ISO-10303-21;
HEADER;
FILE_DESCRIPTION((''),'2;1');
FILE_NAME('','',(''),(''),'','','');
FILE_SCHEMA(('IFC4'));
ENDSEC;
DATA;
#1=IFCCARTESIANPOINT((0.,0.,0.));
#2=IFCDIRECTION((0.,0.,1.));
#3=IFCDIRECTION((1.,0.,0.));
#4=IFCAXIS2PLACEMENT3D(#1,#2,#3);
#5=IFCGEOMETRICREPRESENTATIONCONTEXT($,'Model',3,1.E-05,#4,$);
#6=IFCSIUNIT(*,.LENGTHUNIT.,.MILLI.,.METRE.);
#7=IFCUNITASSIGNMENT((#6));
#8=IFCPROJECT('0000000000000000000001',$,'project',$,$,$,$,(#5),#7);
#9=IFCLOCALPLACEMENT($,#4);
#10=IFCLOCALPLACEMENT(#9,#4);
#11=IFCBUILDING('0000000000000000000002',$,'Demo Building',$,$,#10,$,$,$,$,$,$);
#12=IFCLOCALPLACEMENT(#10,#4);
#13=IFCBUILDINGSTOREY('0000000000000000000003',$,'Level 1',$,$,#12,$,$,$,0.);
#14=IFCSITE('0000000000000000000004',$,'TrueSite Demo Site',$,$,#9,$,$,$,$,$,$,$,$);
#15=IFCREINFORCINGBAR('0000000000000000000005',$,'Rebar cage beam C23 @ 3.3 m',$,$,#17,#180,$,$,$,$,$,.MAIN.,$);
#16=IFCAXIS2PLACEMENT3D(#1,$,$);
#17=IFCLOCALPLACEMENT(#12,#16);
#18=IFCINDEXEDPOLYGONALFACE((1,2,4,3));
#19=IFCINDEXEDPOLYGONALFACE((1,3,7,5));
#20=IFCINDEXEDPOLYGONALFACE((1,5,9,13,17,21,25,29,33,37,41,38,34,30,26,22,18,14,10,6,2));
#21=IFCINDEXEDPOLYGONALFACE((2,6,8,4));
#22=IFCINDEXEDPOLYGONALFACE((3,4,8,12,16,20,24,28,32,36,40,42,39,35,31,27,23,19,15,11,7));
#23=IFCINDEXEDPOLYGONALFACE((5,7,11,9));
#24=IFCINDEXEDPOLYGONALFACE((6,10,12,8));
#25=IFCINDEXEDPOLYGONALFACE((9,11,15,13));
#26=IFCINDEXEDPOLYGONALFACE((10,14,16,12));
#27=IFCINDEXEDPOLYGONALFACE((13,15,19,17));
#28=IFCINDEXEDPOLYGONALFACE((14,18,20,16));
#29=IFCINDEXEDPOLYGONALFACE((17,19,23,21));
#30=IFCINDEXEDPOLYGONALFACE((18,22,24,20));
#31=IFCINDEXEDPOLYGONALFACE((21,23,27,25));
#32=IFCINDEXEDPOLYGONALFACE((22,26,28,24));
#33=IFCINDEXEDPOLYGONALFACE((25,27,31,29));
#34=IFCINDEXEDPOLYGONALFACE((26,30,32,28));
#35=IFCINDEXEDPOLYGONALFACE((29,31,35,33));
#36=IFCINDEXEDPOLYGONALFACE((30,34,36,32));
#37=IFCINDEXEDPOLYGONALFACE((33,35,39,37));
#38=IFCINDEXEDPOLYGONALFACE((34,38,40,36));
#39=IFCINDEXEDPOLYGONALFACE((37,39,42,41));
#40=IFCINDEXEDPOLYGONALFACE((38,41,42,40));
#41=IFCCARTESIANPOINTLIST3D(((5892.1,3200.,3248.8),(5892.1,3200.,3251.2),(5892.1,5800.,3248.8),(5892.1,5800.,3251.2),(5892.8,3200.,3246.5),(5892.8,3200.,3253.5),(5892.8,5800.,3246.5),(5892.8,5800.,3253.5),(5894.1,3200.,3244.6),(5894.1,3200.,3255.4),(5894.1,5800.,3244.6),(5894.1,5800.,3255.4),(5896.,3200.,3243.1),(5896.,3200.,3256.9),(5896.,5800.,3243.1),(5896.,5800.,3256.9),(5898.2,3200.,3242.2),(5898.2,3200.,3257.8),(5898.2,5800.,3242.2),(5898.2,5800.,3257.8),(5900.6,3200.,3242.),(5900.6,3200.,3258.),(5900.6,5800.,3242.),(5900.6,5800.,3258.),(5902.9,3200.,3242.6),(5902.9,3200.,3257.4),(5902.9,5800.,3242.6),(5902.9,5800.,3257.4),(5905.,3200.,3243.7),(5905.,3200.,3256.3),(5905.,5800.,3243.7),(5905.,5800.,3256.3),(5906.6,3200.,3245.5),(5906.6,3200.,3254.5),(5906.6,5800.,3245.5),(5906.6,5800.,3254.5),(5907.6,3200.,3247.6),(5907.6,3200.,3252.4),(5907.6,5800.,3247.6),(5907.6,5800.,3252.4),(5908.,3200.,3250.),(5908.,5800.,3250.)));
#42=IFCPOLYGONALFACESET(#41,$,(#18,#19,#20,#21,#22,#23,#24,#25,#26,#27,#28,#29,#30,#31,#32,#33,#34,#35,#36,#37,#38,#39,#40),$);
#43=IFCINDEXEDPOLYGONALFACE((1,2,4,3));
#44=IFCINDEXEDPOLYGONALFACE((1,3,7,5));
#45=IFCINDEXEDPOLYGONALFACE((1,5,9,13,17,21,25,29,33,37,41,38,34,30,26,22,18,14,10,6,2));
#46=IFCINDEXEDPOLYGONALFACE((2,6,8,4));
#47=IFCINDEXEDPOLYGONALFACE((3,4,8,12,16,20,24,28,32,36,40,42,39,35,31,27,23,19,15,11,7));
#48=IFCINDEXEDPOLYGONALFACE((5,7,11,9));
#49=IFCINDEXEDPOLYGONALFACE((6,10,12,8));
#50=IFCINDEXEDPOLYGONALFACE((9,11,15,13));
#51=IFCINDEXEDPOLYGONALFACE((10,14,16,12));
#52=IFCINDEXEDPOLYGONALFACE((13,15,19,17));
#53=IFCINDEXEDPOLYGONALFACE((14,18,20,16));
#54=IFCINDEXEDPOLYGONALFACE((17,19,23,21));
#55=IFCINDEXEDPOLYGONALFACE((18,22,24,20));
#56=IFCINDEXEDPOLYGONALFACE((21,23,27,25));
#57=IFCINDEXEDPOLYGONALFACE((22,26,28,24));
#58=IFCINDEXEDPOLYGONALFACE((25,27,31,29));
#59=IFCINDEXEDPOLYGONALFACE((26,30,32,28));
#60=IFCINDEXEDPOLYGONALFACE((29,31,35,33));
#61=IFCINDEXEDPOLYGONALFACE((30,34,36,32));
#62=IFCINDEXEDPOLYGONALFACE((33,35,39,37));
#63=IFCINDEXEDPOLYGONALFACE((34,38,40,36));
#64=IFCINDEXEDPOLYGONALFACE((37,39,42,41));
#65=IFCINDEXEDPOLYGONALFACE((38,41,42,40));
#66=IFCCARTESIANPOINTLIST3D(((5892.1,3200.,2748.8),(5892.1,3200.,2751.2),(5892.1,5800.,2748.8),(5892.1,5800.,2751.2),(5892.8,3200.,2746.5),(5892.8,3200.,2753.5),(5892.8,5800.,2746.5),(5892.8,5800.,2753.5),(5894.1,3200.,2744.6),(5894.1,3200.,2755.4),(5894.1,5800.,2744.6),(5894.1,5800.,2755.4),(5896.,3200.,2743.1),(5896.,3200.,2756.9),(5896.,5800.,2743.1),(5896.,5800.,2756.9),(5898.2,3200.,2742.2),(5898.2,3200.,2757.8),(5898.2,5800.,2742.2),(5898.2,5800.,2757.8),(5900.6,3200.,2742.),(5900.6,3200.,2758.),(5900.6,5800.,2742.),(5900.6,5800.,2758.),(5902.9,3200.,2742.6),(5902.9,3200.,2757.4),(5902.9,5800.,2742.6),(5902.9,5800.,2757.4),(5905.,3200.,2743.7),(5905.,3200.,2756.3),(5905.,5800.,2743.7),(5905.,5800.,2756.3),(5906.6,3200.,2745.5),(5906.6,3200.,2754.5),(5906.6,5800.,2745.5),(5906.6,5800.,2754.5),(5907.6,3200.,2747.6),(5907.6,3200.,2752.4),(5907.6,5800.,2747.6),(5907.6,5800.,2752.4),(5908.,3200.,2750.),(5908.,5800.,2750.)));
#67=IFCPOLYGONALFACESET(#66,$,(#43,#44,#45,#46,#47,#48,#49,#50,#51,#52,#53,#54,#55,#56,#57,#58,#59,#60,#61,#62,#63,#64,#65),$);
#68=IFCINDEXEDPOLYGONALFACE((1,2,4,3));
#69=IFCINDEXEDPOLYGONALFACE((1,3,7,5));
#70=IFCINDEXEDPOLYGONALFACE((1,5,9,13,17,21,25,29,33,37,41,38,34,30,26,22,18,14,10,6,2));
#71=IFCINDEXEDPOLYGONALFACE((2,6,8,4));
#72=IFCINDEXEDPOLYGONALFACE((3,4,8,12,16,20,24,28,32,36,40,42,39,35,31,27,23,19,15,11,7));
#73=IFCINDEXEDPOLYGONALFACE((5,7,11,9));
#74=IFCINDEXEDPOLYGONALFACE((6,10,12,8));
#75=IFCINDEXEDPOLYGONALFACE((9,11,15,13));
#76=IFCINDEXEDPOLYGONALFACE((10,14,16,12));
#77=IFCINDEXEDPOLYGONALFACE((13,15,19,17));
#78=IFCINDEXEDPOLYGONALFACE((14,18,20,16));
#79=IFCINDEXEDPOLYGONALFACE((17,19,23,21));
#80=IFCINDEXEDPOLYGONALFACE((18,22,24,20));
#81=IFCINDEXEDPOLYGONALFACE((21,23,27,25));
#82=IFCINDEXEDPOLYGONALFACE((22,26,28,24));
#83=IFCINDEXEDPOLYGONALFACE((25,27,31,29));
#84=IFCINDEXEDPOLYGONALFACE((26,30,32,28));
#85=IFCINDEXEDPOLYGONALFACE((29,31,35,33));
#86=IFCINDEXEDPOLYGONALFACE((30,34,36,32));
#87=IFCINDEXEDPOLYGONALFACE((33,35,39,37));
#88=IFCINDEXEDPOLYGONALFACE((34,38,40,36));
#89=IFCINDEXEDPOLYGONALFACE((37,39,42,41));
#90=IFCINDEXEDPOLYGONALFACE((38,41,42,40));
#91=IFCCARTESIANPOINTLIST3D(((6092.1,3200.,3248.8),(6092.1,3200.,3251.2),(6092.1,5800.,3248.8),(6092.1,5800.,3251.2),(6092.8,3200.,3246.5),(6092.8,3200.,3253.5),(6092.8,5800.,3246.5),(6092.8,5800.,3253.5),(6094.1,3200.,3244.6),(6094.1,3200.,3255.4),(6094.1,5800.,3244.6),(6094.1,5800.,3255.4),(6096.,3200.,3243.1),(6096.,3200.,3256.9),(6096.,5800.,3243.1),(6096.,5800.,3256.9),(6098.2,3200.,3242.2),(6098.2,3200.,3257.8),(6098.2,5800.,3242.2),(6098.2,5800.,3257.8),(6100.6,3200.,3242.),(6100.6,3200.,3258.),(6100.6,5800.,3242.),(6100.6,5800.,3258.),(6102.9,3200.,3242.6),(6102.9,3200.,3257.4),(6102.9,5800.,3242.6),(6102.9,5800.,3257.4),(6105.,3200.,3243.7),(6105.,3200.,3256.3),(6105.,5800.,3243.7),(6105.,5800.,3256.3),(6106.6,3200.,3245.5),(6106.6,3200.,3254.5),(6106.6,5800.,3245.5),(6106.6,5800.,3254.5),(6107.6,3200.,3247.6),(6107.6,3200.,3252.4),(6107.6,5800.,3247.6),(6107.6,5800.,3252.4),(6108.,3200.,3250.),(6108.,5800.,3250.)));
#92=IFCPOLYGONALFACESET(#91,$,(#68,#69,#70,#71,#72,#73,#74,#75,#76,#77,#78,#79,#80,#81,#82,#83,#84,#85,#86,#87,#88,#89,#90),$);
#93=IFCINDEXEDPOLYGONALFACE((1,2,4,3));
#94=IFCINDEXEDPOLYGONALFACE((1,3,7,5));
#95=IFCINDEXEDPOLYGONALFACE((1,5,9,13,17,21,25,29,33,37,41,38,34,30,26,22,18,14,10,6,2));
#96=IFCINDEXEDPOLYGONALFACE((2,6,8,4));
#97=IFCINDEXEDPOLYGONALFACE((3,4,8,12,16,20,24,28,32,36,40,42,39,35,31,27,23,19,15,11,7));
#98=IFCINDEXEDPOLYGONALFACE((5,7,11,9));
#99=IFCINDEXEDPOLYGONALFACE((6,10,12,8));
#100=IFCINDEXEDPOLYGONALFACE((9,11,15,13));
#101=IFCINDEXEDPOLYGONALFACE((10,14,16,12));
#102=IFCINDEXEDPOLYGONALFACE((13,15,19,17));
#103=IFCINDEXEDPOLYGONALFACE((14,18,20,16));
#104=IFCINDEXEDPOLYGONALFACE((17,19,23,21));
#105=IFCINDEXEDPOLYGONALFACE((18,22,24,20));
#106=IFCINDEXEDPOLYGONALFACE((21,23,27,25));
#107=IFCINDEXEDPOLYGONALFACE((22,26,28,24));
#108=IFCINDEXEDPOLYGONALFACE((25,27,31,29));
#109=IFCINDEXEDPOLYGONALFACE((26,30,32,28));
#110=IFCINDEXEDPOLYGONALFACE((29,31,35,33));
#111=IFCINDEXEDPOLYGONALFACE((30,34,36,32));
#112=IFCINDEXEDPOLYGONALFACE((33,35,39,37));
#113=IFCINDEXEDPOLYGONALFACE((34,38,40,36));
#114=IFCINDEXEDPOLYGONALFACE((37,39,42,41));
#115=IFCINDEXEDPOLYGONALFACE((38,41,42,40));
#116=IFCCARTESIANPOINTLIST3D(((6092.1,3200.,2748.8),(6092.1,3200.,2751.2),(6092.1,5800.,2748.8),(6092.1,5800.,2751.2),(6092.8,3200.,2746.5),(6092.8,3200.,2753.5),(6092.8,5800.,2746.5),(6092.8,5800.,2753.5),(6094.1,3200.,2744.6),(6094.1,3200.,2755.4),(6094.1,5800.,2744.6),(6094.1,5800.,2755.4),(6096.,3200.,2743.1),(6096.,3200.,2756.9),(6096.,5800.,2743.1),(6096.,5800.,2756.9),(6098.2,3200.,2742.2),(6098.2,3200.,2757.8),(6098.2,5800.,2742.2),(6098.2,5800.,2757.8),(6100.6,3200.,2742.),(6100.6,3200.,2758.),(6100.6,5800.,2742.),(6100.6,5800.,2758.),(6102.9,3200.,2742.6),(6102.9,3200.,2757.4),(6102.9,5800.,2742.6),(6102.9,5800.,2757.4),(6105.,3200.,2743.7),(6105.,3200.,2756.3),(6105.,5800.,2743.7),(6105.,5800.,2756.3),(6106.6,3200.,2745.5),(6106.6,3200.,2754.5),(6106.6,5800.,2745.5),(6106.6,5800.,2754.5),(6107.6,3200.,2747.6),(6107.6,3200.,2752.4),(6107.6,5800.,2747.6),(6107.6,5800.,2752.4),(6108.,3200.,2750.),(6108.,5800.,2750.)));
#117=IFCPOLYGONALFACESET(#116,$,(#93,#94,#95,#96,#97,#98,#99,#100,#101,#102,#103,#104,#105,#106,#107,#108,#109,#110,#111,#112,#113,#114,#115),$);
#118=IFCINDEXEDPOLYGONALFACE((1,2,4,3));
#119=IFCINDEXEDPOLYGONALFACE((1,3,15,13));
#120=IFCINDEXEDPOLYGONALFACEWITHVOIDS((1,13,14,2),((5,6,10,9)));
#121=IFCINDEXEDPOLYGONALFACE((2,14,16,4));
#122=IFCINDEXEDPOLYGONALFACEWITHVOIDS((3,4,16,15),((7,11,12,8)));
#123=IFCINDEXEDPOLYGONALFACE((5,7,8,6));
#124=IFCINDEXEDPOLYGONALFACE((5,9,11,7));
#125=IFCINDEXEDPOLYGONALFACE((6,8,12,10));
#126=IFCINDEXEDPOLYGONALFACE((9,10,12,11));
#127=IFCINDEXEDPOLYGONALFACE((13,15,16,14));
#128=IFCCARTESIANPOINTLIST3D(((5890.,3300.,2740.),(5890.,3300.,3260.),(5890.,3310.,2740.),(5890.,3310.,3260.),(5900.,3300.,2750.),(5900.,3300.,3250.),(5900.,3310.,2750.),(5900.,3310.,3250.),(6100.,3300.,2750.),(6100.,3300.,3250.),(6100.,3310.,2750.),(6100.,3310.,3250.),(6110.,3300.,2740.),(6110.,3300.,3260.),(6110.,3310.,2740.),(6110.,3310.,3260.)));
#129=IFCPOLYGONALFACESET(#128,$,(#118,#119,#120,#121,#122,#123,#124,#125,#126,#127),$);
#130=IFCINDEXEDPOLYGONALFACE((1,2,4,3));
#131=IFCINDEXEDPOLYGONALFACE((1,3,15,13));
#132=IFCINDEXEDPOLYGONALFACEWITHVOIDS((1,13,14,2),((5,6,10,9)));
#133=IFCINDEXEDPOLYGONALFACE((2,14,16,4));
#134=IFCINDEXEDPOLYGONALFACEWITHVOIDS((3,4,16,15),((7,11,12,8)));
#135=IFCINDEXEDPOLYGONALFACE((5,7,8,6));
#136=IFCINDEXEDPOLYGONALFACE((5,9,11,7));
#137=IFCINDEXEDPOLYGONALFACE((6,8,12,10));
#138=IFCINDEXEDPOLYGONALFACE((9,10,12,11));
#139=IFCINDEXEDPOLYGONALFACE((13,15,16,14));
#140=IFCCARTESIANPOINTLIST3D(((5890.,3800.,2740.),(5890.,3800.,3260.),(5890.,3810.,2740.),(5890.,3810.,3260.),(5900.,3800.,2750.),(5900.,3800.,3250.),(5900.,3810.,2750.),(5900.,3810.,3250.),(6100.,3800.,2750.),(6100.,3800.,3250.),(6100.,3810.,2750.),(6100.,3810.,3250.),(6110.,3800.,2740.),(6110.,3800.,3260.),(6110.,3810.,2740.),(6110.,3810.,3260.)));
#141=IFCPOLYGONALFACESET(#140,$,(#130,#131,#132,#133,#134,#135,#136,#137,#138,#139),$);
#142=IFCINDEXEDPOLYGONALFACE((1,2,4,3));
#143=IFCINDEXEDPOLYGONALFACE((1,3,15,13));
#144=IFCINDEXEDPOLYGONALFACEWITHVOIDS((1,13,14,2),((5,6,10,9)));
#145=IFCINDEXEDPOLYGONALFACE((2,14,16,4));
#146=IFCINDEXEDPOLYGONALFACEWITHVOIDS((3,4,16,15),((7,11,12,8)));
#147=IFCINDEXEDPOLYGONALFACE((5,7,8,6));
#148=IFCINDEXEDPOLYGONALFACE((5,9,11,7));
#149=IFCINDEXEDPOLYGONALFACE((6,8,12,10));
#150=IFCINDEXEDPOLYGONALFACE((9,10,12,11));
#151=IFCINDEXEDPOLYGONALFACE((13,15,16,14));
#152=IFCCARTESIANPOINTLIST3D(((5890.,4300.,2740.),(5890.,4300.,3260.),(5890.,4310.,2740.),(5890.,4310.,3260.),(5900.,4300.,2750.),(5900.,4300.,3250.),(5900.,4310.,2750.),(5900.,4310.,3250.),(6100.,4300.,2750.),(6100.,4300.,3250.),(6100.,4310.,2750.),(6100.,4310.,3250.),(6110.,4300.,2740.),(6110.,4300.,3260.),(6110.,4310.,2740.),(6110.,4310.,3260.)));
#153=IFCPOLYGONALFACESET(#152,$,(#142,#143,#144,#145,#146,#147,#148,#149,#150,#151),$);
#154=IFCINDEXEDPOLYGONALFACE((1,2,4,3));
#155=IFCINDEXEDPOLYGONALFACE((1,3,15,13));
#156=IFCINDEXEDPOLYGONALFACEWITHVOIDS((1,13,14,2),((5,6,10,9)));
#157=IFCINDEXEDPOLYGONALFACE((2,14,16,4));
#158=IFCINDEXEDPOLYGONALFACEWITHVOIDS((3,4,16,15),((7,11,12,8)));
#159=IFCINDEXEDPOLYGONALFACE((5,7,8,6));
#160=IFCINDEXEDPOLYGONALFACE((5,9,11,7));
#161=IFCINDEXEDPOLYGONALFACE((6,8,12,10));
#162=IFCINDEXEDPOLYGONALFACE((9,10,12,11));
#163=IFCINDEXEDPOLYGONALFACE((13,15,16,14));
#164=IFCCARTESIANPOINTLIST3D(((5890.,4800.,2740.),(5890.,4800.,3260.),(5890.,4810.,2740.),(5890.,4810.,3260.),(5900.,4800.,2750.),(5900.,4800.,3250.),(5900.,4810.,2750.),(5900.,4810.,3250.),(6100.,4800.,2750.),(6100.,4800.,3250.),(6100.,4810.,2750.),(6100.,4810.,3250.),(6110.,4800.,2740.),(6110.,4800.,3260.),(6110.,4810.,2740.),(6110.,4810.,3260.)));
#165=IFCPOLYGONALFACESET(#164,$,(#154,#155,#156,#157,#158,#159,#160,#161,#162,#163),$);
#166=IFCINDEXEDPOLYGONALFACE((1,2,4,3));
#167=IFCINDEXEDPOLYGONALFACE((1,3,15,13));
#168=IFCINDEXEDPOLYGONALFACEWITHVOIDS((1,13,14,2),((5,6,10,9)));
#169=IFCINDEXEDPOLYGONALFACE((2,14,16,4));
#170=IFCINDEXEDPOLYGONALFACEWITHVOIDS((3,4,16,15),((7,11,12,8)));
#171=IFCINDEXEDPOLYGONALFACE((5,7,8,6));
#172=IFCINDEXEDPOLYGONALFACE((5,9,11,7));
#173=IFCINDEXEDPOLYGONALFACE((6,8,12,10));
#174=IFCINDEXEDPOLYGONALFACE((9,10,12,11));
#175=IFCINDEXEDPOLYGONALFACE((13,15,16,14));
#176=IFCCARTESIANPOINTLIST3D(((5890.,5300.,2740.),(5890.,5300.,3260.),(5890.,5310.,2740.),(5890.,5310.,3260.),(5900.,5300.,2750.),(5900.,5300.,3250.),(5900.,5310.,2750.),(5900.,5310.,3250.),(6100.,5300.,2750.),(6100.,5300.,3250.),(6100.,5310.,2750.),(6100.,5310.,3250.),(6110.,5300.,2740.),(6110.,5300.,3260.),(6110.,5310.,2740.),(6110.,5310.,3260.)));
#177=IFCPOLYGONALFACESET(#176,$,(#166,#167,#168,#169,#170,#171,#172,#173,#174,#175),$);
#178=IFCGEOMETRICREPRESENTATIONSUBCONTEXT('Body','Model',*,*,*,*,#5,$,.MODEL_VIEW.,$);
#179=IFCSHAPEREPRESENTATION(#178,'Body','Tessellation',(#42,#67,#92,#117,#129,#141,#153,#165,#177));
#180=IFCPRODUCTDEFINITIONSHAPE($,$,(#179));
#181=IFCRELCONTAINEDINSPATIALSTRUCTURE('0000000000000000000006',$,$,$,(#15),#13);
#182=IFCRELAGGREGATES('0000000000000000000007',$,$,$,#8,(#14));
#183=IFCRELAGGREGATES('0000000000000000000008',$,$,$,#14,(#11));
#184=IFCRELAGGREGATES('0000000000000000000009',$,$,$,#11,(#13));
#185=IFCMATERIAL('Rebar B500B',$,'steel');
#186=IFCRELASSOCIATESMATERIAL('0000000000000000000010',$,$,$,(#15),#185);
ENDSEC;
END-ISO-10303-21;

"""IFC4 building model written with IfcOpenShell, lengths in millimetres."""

from ifc_helpers import new_model, si_unit, frame, origin_with_axes, place, context, subcontext, project, spatial, hollow_rectangle, circle, extrude, material, element, save


model = new_model("IFC4")

# Units and contexts
model_context = context("Model", 3, precision=1e-05, world=origin_with_axes())
body_context = subcontext(model_context, "Body", "Model", "MODEL_VIEW")
ifc_project = project(units=[si_unit("LENGTHUNIT", "METRE", prefix="MILLI")], contexts=[model_context])

# Site, building, storey
site_placement = place(None, origin_with_axes())
site = spatial("IfcSite", under=ifc_project, at=site_placement, Name="TrueSite Demo Site")
building_placement = place(site_placement, origin_with_axes())
building = spatial("IfcBuilding", under=site, at=building_placement, Name="Demo Building")
storey_placement = place(building_placement, origin_with_axes())
storey = spatial("IfcBuildingStorey", under=building, at=storey_placement, Name="Level 1", Elevation=0.0)

# Reinforcing bar
ifc_material_1 = material(Name="Rebar B500B", Category="steel")
for number, where, z_axis, x_axis, name in (
    (1, (6000.0, 3200.0, 3000.0), (0.0, 1.0, 0.0), (1.0, 0.0, 0.0), "Rebar cage beam C23 @ 3.3 m"),
):
    element("IfcReinforcingBar", number, at=place(storey_placement, frame(where, z_axis=z_axis, x_axis=x_axis)), inside=storey, material=ifc_material_1, Name=name, PredefinedType="MAIN", context=body_context, shape_type="SweptSolid", body=[
        extrude(circle(Radius=8.0), frame((-100.0, -250.0, 0.0)), (0.0, 0.0, 1.0), 2600.0),
        extrude(circle(Radius=8.0), frame((-100.0, 250.0, 0.0)), (0.0, 0.0, 1.0), 2600.0),
        extrude(circle(Radius=8.0), frame((100.0, -250.0, 0.0)), (0.0, 0.0, 1.0), 2600.0),
        extrude(circle(Radius=8.0), frame((100.0, 250.0, 0.0)), (0.0, 0.0, 1.0), 2600.0),
        extrude(hollow_rectangle(XDim=220.0, YDim=520.0, WallThickness=10.0), frame((0.0, 0.0, 100.0)), (0.0, 0.0, 1.0), 10.0),
        extrude(hollow_rectangle(XDim=220.0, YDim=520.0, WallThickness=10.0), frame((0.0, 0.0, 600.0)), (0.0, 0.0, 1.0), 10.0),
        extrude(hollow_rectangle(XDim=220.0, YDim=520.0, WallThickness=10.0), frame((0.0, 0.0, 1100.0)), (0.0, 0.0, 1.0), 10.0),
        extrude(hollow_rectangle(XDim=220.0, YDim=520.0, WallThickness=10.0), frame((0.0, 0.0, 1600.0)), (0.0, 0.0, 1.0), 10.0),
        extrude(hollow_rectangle(XDim=220.0, YDim=520.0, WallThickness=10.0), frame((0.0, 0.0, 2100.0)), (0.0, 0.0, 1.0), 10.0),
    ])

save(model, "model.ifc")
